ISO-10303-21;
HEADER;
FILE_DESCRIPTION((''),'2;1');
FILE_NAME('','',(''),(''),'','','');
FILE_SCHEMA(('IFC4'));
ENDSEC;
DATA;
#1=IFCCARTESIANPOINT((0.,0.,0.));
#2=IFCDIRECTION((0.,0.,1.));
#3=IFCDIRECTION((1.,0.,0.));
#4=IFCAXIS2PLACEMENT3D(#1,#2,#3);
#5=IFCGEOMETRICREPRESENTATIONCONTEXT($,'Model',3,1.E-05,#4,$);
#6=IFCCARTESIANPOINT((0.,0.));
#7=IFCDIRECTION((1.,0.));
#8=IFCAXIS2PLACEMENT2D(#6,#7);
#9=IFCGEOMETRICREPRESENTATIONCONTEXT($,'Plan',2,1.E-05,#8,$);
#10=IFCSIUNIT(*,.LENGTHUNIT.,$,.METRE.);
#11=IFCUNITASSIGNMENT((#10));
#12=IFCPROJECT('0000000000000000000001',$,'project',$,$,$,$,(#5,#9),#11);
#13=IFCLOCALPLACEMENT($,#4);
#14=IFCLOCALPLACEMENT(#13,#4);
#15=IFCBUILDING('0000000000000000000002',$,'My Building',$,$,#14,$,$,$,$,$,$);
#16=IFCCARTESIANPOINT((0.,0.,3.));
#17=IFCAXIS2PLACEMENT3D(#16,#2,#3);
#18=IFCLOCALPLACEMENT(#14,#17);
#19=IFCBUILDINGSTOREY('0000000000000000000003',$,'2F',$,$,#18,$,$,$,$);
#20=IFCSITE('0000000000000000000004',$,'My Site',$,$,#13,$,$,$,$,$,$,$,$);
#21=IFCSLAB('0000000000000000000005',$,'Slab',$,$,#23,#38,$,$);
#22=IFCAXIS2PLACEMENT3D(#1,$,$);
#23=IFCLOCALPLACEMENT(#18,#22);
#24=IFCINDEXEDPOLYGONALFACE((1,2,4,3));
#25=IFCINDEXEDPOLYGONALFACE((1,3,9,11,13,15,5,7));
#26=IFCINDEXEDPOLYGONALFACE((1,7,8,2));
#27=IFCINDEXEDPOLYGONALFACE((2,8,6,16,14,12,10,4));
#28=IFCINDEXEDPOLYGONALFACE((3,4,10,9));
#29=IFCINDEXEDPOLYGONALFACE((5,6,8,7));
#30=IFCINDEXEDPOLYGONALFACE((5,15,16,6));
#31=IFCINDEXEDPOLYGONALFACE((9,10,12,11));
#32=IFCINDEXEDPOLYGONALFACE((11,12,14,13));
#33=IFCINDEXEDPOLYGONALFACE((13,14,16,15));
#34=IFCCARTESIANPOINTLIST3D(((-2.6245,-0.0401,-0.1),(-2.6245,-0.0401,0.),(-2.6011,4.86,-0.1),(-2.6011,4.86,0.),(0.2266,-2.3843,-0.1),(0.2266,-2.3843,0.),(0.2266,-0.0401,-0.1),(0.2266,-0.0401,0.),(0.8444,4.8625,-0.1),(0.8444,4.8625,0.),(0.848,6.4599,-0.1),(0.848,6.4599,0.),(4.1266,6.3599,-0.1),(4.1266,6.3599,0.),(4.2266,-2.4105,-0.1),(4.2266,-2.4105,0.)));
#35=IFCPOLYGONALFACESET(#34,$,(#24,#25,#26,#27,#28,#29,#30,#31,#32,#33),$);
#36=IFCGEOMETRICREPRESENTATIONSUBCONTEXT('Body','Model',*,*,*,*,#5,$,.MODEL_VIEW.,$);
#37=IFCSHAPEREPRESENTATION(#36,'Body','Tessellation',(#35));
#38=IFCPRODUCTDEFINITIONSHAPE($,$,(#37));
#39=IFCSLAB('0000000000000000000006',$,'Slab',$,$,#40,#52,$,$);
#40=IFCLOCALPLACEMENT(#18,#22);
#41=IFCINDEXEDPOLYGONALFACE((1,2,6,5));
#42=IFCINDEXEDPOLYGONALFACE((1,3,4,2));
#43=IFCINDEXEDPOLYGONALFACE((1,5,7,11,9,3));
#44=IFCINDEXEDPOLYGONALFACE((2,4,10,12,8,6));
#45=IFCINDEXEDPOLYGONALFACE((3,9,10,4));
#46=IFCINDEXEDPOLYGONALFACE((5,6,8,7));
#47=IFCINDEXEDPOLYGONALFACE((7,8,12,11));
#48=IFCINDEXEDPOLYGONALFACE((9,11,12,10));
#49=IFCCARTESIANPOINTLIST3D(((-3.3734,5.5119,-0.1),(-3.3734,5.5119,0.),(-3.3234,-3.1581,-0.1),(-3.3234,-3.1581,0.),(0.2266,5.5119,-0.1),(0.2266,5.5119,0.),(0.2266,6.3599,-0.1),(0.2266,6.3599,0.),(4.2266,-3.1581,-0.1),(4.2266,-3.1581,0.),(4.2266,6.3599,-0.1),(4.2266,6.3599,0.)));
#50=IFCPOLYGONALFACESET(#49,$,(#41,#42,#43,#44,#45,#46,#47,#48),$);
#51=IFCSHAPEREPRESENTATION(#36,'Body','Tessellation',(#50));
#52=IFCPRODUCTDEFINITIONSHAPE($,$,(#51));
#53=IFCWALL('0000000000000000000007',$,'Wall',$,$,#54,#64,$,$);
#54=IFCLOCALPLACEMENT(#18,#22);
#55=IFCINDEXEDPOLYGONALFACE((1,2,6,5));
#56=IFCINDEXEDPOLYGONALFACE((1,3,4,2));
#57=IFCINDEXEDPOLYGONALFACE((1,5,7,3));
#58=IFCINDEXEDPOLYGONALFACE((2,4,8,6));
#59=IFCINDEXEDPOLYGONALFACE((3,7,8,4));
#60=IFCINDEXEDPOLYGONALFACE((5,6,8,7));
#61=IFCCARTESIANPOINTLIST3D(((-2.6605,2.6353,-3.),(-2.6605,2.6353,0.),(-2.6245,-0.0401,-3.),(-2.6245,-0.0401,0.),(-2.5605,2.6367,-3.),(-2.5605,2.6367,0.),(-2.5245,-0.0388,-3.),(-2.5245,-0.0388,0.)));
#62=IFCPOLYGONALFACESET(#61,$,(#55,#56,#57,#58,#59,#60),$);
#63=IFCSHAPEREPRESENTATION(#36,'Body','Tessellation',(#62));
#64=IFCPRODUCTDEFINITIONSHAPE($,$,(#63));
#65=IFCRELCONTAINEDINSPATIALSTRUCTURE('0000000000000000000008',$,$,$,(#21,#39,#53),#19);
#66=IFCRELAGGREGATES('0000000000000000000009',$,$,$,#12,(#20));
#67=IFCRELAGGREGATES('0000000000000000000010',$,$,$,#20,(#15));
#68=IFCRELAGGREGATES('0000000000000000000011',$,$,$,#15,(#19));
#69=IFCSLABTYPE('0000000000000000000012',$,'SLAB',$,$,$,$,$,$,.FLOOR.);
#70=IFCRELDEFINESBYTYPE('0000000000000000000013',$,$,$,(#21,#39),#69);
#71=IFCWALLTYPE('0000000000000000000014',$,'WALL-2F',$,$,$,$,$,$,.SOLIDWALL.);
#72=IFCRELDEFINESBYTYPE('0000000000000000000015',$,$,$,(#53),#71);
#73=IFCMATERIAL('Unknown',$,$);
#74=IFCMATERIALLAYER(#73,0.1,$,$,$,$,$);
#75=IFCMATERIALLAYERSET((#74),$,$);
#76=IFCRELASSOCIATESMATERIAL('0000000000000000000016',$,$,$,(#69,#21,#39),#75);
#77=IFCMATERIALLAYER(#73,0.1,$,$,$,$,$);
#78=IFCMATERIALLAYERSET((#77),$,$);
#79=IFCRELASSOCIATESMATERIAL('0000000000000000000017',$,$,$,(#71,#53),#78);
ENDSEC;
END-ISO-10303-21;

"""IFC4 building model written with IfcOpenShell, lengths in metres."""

from ifc_helpers import new_model, si_unit, frame, origin_with_axes, origin_2d_with_axis, place, context, subcontext, project, spatial, line, indexed_curve, outline, extrude, material, layer, layer_set, layer_usage, type_object, element, save


model = new_model("IFC4")

# Units and contexts
model_context = context("Model", 3, precision=1e-05, world=origin_with_axes())
plan_context = context("Plan", 2, precision=1e-05, world=origin_2d_with_axis())
body_context_1 = subcontext(model_context, "Body", "Model", "MODEL_VIEW")
ifc_project = project(units=[si_unit("LENGTHUNIT", "METRE")], contexts=[model_context, plan_context])

# Site, building, storey
site_placement = place(None, origin_with_axes())
site = spatial("IfcSite", under=ifc_project, at=site_placement, Name="My Site")
building_placement = place(site_placement, origin_with_axes())
building = spatial("IfcBuilding", under=site, at=building_placement, Name="My Building")
storey_placement = place(building_placement, frame((0.0, 0.0, 3.0), z_axis=(0.0, 0.0, 1.0), x_axis=(1.0, 0.0, 0.0)))
storey = spatial("IfcBuildingStorey", under=building, at=storey_placement, Name="2F")

# Slabs
ifc_material = material(Name="Unknown")
ifc_layer_1 = layer(ifc_material, 0.1)
ifc_layer_set_1 = layer_set([ifc_layer_1])
ifc_layer_usage_1 = layer_usage(ifc_layer_set_1, "AXIS3", "POSITIVE", -0.1)
slab_type = type_object("IfcSlabType", Name="SLAB", PredefinedType="FLOOR", material=ifc_layer_set_1)
slab_1_placement = place(storey_placement, frame((-2.6011, 4.86, 0.0), z_axis=(0.0, 0.0, 1.0), x_axis=(1.0, 0.0, 0.0)))
element("IfcSlab", 1, at=slab_1_placement, inside=storey, type_object=slab_type, material=ifc_layer_usage_1, Name="Slab", context=body_context_1, shape_type="SweptSolid", body=[
    extrude(outline(indexed_curve([(0.0, 0.0), (3.4455, 0.0025), (3.4491, 1.5999), (6.7277, 1.4999), (6.8277, -7.2705), (2.8277, -7.2443), (2.8277, -4.9001), (-0.0234, -4.9001), (0.0, 0.0)])), frame((0.0, 0.0, -0.1), z_axis=(0.0, 0.0, 1.0), x_axis=(1.0, 0.0, 0.0)), (0.0, 0.0, 1.0), 0.1),
])
ifc_layer_usage_2 = layer_usage(ifc_layer_set_1, "AXIS3", "POSITIVE", -0.1)
slab_2_placement = place(storey_placement, frame((-3.3734, 5.5119, 0.0), z_axis=(0.0, 0.0, 1.0), x_axis=(1.0, 0.0, 0.0)))
element("IfcSlab", 2, at=slab_2_placement, inside=storey, type_object=slab_type, material=ifc_layer_usage_2, Name="Slab", context=body_context_1, shape_type="SweptSolid", body=[
    extrude(outline(indexed_curve([(0.0, 0.0), (3.6, 0.0), (3.6, 0.848), (7.6, 0.848), (7.6, -8.67), (0.05, -8.67), (0.0, 0.0)])), frame((0.0, 0.0, -0.1), z_axis=(0.0, 0.0, 1.0), x_axis=(1.0, 0.0, 0.0)), (0.0, 0.0, 1.0), 0.1),
])

# Wall
ifc_layer_2 = layer(ifc_material, 0.1)
ifc_layer_set_2 = layer_set([ifc_layer_2])
ifc_layer_usage_3 = layer_usage(ifc_layer_set_2, "AXIS2", "POSITIVE", 0.0)
wall_type = type_object("IfcWallType", Name="WALL-2F", PredefinedType="SOLIDWALL", material=ifc_layer_set_2)
wall_1_placement = place(storey_placement, frame((-2.6605, 2.6353, -3.0), z_axis=(0.0, 0.0, 1.0), x_axis=(0.013468, -0.999909, 0.0)))
element("IfcWall", 3, at=wall_1_placement, inside=storey, type_object=wall_type, material=ifc_layer_usage_3, Name="Wall", context=body_context_1, shape_type="SweptSolid", body=[
    extrude(outline(indexed_curve([(0.0, 0.0), (0.0, 0.1), (2.6757, 0.1), (2.6757, 0.0)], segments=[line(1, 2, 3, 4, 1)])), origin_with_axes(), (0.0, 0.0, 1.0), 3.0),
])

save(model, "model.ifc")
